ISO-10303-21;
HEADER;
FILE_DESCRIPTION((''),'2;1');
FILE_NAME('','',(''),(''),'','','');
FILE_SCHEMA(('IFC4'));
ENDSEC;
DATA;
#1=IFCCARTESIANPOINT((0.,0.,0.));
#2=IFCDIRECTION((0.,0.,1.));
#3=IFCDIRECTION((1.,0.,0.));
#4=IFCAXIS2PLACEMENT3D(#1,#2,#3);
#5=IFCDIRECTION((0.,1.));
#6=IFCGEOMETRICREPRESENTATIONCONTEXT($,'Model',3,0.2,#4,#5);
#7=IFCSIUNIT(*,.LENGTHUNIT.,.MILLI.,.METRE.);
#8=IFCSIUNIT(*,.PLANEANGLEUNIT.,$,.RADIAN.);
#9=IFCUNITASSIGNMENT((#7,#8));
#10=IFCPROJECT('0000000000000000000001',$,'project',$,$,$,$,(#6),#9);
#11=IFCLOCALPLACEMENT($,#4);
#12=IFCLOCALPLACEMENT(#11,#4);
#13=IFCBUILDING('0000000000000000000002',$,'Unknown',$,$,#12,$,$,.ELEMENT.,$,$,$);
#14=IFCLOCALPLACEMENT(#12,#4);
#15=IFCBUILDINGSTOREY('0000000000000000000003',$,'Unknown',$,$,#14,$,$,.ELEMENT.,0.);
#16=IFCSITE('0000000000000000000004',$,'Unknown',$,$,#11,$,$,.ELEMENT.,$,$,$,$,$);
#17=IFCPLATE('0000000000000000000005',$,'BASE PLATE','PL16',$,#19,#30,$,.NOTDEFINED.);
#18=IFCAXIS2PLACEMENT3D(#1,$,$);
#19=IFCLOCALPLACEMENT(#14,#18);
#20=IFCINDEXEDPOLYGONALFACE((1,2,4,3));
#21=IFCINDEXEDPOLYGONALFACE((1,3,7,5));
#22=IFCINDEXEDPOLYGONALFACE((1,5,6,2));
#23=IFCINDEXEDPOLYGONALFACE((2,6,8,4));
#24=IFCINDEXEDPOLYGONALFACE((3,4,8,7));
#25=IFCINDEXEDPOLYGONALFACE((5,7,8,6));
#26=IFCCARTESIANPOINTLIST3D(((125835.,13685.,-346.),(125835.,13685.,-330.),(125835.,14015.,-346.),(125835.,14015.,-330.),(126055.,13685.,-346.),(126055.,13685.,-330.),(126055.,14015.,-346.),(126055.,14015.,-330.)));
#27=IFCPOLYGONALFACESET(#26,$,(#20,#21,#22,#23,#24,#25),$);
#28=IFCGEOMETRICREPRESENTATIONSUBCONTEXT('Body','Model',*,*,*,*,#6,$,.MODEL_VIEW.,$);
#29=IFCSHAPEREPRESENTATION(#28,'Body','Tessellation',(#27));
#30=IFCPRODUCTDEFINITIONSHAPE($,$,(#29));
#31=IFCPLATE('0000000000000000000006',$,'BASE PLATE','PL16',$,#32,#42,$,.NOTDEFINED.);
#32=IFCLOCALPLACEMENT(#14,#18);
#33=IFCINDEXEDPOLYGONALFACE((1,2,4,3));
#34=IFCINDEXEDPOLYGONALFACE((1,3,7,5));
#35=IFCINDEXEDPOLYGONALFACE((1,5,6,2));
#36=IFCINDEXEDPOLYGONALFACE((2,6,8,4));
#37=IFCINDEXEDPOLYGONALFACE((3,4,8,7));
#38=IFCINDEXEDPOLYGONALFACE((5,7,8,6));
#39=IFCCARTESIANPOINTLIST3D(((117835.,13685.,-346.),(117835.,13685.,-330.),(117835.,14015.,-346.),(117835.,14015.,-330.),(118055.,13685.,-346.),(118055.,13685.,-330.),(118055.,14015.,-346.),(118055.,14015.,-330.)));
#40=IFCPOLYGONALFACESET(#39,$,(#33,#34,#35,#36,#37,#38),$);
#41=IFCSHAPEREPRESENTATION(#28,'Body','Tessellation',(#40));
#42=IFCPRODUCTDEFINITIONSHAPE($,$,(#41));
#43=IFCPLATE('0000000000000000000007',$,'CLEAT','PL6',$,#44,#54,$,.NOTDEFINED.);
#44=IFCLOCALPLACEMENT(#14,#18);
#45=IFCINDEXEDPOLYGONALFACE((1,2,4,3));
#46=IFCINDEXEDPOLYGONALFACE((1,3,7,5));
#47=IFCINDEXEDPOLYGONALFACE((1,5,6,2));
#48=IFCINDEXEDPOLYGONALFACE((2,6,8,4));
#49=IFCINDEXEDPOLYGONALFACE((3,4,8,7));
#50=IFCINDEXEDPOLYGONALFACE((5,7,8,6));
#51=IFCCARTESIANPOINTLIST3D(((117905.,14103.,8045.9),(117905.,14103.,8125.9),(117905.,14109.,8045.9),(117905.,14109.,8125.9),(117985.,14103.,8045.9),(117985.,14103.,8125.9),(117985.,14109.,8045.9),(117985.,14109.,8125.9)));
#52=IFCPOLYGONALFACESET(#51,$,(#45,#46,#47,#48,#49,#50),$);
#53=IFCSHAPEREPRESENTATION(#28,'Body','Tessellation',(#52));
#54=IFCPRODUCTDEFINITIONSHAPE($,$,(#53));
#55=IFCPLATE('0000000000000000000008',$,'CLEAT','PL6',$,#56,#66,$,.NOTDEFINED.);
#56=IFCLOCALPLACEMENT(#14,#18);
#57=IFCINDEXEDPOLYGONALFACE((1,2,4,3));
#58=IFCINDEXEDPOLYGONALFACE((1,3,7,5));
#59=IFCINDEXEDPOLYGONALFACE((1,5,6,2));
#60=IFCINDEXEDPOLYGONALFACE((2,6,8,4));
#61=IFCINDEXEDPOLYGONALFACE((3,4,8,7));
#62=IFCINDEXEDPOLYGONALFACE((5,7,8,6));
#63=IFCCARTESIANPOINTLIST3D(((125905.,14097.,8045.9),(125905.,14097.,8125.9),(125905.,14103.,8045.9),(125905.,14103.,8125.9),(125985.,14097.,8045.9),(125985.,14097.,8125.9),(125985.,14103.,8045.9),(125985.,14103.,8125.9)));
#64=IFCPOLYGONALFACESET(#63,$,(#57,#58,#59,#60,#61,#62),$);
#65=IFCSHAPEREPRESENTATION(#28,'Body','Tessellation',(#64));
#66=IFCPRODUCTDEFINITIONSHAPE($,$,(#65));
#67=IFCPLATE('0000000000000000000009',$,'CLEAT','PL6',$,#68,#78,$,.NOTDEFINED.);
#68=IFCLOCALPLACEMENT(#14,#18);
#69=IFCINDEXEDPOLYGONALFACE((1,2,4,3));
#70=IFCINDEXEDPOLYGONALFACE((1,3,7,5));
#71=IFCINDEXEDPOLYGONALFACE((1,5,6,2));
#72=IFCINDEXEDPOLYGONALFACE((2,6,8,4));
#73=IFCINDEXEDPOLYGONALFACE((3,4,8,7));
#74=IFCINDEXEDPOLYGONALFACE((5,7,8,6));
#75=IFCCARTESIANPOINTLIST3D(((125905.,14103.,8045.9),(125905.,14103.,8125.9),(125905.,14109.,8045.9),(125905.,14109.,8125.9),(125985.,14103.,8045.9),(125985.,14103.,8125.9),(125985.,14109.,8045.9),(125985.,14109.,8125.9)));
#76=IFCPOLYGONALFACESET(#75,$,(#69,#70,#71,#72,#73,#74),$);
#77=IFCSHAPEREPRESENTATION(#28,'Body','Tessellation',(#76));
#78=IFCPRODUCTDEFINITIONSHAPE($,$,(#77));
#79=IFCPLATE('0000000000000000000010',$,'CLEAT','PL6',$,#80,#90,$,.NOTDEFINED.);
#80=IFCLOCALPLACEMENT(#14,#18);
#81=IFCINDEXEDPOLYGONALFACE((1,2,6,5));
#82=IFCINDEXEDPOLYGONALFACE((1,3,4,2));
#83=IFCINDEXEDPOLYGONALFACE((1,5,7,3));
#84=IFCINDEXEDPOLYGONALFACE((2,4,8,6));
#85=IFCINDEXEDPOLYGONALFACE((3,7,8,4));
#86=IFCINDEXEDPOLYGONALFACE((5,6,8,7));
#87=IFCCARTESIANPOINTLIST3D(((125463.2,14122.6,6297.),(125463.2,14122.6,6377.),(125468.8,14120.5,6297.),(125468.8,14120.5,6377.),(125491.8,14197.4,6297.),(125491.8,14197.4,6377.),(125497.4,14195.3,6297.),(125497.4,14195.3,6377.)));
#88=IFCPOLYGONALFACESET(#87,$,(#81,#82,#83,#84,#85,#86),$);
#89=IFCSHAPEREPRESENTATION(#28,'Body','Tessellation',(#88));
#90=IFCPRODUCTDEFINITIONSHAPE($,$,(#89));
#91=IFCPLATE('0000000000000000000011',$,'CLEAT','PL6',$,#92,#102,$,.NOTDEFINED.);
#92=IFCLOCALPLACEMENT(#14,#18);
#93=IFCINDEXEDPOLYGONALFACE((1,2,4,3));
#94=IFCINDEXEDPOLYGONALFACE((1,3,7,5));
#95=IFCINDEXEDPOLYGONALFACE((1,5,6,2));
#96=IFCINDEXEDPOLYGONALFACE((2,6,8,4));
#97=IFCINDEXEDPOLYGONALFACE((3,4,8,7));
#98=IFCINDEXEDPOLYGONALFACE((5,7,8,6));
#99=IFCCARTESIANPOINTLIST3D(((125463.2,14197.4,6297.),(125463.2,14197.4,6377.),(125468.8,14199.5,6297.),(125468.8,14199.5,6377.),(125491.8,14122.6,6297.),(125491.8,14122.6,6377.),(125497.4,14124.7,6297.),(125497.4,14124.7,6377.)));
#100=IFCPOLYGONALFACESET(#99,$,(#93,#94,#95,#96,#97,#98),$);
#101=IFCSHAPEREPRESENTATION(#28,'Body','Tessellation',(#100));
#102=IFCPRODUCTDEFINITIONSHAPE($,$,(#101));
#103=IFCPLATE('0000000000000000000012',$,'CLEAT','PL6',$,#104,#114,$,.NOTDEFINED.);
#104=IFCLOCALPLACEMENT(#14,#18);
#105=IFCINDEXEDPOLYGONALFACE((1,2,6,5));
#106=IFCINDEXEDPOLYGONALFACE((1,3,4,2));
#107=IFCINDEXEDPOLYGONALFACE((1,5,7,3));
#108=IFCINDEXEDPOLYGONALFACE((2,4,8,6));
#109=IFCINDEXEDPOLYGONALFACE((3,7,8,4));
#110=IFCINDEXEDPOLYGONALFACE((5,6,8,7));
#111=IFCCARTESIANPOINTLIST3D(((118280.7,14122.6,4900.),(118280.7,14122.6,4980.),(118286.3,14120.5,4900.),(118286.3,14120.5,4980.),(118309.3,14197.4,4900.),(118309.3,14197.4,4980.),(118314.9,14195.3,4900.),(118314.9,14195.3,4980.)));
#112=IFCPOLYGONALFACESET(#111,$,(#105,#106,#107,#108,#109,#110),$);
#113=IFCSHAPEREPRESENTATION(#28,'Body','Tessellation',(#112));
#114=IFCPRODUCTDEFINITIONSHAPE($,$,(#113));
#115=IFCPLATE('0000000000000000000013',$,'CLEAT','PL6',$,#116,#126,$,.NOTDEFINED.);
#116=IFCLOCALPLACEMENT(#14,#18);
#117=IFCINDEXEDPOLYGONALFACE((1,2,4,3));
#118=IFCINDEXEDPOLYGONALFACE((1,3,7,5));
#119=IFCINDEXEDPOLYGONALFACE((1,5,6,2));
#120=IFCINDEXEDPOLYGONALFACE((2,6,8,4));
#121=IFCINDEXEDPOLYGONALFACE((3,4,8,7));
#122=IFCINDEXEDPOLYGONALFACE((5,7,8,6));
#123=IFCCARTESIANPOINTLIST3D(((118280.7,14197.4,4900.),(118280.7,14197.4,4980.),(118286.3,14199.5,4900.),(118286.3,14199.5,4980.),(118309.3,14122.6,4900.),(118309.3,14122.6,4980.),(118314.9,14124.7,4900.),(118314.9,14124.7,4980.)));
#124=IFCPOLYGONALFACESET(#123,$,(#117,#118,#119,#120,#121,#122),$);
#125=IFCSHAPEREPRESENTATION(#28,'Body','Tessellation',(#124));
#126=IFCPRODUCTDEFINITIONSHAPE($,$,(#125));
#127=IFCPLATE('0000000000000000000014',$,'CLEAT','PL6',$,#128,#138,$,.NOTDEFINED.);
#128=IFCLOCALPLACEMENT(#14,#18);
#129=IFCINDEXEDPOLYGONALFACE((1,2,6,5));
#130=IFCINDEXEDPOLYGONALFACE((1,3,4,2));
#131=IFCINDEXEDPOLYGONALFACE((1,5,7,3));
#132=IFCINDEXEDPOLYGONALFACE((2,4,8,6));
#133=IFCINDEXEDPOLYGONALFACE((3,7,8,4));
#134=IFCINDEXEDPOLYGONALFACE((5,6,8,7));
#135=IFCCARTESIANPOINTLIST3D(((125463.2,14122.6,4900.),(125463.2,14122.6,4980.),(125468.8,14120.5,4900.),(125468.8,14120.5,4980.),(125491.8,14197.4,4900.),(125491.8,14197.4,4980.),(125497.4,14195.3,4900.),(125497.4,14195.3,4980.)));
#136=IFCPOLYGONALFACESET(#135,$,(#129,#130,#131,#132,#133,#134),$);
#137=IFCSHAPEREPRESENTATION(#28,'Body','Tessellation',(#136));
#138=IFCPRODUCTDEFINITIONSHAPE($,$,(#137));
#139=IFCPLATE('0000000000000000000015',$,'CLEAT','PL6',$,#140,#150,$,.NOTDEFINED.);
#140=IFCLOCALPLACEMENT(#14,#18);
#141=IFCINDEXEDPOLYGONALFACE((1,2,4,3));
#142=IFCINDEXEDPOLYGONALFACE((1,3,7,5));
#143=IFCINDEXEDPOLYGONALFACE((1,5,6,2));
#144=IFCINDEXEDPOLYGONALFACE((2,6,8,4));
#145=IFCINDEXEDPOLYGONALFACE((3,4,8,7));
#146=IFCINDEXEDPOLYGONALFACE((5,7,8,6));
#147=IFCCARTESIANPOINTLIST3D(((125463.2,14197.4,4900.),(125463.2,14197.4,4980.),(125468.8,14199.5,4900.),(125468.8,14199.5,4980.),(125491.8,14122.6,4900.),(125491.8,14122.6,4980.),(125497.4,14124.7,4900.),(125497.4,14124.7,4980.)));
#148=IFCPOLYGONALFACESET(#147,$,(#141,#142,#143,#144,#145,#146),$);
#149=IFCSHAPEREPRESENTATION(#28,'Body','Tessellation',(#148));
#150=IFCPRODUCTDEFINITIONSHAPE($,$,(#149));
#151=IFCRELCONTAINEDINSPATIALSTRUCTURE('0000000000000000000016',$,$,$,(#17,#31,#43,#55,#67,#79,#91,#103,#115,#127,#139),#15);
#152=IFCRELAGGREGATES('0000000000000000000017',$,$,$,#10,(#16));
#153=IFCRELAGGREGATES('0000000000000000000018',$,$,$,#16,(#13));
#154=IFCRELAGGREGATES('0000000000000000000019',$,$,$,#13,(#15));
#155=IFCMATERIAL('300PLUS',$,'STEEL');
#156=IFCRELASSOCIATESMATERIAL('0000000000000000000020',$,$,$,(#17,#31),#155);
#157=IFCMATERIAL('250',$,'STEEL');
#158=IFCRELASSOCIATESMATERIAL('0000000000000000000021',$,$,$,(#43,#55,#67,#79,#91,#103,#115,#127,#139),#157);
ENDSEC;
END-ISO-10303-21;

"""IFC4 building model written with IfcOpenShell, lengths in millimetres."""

from ifc_helpers import new_model, si_unit, direction, frame, origin_with_axes, place, context, subcontext, project, spatial, line, indexed_curve, outline, extrude, material, element, save


model = new_model("IFC4")

# Units and contexts
model_context = context("Model", 3, precision=0.2, world=origin_with_axes(), true_north=direction((0.0, 1.0)))
body_context = subcontext(model_context, "Body", "Model", "MODEL_VIEW")
ifc_project = project(units=[si_unit("LENGTHUNIT", "METRE", prefix="MILLI"), si_unit("PLANEANGLEUNIT", "RADIAN")], contexts=[model_context])

# Site, building, storey
site_placement = place(None, origin_with_axes())
site = spatial("IfcSite", under=ifc_project, at=site_placement, Name="Unknown", CompositionType="ELEMENT")
building_placement = place(site_placement, origin_with_axes())
building = spatial("IfcBuilding", under=site, at=building_placement, Name="Unknown", CompositionType="ELEMENT")
storey_placement = place(building_placement, origin_with_axes())
storey = spatial("IfcBuildingStorey", under=building, at=storey_placement, Name="Unknown", CompositionType="ELEMENT", Elevation=0.0)

# Shared definitions
ifc_material_1 = material(Name="300PLUS", Category="STEEL")

# Plates
for number, where, z_axis, x_axis, name in (
    (1, (126055.0, 13685.0, -338.0), (0.0, 0.0, 1.0), (0.0, 1.0, 0.0), "BASE PLATE"),
    (2, (118055.0, 13685.0, -338.0), (0.0, 0.0, 1.0), (0.0, 1.0, 0.0), "BASE PLATE"),
):
    element("IfcPlate", number, at=place(storey_placement, frame(where, z_axis=z_axis, x_axis=x_axis)), inside=storey, material=ifc_material_1, Name=name, Description="PL16", PredefinedType="NOTDEFINED", context=body_context, shape_type="SolidModel", body=[
        extrude(outline(indexed_curve([(0.0, 0.0), (330.0, 0.0), (330.0, 220.0), (0.0, 220.0)], segments=[line(1, 2, 3, 4, 1)])), frame((0.0, 0.0, 8.0), z_axis=(0.0, 0.0, 1.0), x_axis=(1.0, 0.0, 0.0)), (0.0, 0.0, -1.0), 16.0),
    ])
ifc_material_2 = material(Name="250", Category="STEEL")
for number, where, z_axis, x_axis, name in (
    (3, (117985.0, 14106.0, 8045.9), (0.0, 1.0, 0.0), (-1.0, 0.0, 0.0), "CLEAT"),
    (4, (125905.0, 14100.0, 8045.9), (0.0, -1.0, 0.0), (1.0, 0.0, 0.0), "CLEAT"),
    (5, (125985.0, 14106.0, 8045.9), (0.0, 1.0, 0.0), (-1.0, 0.0, 0.0), "CLEAT"),
):
    element("IfcPlate", number, at=place(storey_placement, frame(where, z_axis=z_axis, x_axis=x_axis)), inside=storey, material=ifc_material_2, Name=name, Description="PL6", PredefinedType="NOTDEFINED", context=body_context, shape_type="SolidModel", body=[
        extrude(outline(indexed_curve([(0.0, 0.0), (80.0, 0.0), (80.0, 80.0), (0.0, 80.0)], segments=[line(1, 2, 3, 4, 1)])), frame((0.0, 0.0, 3.0), z_axis=(0.0, 0.0, 1.0), x_axis=(1.0, 0.0, 0.0)), (0.0, 0.0, -1.0), 6.0),
    ])
for number, where, z_axis, x_axis, name in (
    (6, (125466.0, 14121.5, 6297.0), (0.934052, -0.357137, 0.0), (0.357137, 0.934052, 0.0), "CLEAT"),
    (7, (125494.6, 14123.7, 6297.0), (0.934052, 0.357137, 0.0), (-0.357137, 0.934052, 0.0), "CLEAT"),
    (8, (118283.5, 14121.5, 4900.0), (0.934052, -0.357137, 0.0), (0.357137, 0.934052, 0.0), "CLEAT"),
    (9, (118312.1, 14123.7, 4900.0), (0.934052, 0.357137, 0.0), (-0.357137, 0.934052, 0.0), "CLEAT"),
    (10, (125466.0, 14121.5, 4900.0), (0.934052, -0.357137, 0.0), (0.357137, 0.934052, 0.0), "CLEAT"),
    (11, (125494.6, 14123.7, 4900.0), (0.934052, 0.357137, 0.0), (-0.357137, 0.934052, 0.0), "CLEAT"),
):
    element("IfcPlate", number, at=place(storey_placement, frame(where, z_axis=z_axis, x_axis=x_axis)), inside=storey, material=ifc_material_2, Name=name, Description="PL6", PredefinedType="NOTDEFINED", context=body_context, shape_type="SolidModel", body=[
        extrude(outline(indexed_curve([(0.0, 0.0), (80.1, 0.0), (80.1, 80.0), (0.0, 80.0)], segments=[line(1, 2, 3, 4, 1)])), frame((0.0, 0.0, 3.0), z_axis=(0.0, 0.0, 1.0), x_axis=(1.0, 0.0, 0.0)), (0.0, 0.0, -1.0), 6.0),
    ])

save(model, "model.ifc")
